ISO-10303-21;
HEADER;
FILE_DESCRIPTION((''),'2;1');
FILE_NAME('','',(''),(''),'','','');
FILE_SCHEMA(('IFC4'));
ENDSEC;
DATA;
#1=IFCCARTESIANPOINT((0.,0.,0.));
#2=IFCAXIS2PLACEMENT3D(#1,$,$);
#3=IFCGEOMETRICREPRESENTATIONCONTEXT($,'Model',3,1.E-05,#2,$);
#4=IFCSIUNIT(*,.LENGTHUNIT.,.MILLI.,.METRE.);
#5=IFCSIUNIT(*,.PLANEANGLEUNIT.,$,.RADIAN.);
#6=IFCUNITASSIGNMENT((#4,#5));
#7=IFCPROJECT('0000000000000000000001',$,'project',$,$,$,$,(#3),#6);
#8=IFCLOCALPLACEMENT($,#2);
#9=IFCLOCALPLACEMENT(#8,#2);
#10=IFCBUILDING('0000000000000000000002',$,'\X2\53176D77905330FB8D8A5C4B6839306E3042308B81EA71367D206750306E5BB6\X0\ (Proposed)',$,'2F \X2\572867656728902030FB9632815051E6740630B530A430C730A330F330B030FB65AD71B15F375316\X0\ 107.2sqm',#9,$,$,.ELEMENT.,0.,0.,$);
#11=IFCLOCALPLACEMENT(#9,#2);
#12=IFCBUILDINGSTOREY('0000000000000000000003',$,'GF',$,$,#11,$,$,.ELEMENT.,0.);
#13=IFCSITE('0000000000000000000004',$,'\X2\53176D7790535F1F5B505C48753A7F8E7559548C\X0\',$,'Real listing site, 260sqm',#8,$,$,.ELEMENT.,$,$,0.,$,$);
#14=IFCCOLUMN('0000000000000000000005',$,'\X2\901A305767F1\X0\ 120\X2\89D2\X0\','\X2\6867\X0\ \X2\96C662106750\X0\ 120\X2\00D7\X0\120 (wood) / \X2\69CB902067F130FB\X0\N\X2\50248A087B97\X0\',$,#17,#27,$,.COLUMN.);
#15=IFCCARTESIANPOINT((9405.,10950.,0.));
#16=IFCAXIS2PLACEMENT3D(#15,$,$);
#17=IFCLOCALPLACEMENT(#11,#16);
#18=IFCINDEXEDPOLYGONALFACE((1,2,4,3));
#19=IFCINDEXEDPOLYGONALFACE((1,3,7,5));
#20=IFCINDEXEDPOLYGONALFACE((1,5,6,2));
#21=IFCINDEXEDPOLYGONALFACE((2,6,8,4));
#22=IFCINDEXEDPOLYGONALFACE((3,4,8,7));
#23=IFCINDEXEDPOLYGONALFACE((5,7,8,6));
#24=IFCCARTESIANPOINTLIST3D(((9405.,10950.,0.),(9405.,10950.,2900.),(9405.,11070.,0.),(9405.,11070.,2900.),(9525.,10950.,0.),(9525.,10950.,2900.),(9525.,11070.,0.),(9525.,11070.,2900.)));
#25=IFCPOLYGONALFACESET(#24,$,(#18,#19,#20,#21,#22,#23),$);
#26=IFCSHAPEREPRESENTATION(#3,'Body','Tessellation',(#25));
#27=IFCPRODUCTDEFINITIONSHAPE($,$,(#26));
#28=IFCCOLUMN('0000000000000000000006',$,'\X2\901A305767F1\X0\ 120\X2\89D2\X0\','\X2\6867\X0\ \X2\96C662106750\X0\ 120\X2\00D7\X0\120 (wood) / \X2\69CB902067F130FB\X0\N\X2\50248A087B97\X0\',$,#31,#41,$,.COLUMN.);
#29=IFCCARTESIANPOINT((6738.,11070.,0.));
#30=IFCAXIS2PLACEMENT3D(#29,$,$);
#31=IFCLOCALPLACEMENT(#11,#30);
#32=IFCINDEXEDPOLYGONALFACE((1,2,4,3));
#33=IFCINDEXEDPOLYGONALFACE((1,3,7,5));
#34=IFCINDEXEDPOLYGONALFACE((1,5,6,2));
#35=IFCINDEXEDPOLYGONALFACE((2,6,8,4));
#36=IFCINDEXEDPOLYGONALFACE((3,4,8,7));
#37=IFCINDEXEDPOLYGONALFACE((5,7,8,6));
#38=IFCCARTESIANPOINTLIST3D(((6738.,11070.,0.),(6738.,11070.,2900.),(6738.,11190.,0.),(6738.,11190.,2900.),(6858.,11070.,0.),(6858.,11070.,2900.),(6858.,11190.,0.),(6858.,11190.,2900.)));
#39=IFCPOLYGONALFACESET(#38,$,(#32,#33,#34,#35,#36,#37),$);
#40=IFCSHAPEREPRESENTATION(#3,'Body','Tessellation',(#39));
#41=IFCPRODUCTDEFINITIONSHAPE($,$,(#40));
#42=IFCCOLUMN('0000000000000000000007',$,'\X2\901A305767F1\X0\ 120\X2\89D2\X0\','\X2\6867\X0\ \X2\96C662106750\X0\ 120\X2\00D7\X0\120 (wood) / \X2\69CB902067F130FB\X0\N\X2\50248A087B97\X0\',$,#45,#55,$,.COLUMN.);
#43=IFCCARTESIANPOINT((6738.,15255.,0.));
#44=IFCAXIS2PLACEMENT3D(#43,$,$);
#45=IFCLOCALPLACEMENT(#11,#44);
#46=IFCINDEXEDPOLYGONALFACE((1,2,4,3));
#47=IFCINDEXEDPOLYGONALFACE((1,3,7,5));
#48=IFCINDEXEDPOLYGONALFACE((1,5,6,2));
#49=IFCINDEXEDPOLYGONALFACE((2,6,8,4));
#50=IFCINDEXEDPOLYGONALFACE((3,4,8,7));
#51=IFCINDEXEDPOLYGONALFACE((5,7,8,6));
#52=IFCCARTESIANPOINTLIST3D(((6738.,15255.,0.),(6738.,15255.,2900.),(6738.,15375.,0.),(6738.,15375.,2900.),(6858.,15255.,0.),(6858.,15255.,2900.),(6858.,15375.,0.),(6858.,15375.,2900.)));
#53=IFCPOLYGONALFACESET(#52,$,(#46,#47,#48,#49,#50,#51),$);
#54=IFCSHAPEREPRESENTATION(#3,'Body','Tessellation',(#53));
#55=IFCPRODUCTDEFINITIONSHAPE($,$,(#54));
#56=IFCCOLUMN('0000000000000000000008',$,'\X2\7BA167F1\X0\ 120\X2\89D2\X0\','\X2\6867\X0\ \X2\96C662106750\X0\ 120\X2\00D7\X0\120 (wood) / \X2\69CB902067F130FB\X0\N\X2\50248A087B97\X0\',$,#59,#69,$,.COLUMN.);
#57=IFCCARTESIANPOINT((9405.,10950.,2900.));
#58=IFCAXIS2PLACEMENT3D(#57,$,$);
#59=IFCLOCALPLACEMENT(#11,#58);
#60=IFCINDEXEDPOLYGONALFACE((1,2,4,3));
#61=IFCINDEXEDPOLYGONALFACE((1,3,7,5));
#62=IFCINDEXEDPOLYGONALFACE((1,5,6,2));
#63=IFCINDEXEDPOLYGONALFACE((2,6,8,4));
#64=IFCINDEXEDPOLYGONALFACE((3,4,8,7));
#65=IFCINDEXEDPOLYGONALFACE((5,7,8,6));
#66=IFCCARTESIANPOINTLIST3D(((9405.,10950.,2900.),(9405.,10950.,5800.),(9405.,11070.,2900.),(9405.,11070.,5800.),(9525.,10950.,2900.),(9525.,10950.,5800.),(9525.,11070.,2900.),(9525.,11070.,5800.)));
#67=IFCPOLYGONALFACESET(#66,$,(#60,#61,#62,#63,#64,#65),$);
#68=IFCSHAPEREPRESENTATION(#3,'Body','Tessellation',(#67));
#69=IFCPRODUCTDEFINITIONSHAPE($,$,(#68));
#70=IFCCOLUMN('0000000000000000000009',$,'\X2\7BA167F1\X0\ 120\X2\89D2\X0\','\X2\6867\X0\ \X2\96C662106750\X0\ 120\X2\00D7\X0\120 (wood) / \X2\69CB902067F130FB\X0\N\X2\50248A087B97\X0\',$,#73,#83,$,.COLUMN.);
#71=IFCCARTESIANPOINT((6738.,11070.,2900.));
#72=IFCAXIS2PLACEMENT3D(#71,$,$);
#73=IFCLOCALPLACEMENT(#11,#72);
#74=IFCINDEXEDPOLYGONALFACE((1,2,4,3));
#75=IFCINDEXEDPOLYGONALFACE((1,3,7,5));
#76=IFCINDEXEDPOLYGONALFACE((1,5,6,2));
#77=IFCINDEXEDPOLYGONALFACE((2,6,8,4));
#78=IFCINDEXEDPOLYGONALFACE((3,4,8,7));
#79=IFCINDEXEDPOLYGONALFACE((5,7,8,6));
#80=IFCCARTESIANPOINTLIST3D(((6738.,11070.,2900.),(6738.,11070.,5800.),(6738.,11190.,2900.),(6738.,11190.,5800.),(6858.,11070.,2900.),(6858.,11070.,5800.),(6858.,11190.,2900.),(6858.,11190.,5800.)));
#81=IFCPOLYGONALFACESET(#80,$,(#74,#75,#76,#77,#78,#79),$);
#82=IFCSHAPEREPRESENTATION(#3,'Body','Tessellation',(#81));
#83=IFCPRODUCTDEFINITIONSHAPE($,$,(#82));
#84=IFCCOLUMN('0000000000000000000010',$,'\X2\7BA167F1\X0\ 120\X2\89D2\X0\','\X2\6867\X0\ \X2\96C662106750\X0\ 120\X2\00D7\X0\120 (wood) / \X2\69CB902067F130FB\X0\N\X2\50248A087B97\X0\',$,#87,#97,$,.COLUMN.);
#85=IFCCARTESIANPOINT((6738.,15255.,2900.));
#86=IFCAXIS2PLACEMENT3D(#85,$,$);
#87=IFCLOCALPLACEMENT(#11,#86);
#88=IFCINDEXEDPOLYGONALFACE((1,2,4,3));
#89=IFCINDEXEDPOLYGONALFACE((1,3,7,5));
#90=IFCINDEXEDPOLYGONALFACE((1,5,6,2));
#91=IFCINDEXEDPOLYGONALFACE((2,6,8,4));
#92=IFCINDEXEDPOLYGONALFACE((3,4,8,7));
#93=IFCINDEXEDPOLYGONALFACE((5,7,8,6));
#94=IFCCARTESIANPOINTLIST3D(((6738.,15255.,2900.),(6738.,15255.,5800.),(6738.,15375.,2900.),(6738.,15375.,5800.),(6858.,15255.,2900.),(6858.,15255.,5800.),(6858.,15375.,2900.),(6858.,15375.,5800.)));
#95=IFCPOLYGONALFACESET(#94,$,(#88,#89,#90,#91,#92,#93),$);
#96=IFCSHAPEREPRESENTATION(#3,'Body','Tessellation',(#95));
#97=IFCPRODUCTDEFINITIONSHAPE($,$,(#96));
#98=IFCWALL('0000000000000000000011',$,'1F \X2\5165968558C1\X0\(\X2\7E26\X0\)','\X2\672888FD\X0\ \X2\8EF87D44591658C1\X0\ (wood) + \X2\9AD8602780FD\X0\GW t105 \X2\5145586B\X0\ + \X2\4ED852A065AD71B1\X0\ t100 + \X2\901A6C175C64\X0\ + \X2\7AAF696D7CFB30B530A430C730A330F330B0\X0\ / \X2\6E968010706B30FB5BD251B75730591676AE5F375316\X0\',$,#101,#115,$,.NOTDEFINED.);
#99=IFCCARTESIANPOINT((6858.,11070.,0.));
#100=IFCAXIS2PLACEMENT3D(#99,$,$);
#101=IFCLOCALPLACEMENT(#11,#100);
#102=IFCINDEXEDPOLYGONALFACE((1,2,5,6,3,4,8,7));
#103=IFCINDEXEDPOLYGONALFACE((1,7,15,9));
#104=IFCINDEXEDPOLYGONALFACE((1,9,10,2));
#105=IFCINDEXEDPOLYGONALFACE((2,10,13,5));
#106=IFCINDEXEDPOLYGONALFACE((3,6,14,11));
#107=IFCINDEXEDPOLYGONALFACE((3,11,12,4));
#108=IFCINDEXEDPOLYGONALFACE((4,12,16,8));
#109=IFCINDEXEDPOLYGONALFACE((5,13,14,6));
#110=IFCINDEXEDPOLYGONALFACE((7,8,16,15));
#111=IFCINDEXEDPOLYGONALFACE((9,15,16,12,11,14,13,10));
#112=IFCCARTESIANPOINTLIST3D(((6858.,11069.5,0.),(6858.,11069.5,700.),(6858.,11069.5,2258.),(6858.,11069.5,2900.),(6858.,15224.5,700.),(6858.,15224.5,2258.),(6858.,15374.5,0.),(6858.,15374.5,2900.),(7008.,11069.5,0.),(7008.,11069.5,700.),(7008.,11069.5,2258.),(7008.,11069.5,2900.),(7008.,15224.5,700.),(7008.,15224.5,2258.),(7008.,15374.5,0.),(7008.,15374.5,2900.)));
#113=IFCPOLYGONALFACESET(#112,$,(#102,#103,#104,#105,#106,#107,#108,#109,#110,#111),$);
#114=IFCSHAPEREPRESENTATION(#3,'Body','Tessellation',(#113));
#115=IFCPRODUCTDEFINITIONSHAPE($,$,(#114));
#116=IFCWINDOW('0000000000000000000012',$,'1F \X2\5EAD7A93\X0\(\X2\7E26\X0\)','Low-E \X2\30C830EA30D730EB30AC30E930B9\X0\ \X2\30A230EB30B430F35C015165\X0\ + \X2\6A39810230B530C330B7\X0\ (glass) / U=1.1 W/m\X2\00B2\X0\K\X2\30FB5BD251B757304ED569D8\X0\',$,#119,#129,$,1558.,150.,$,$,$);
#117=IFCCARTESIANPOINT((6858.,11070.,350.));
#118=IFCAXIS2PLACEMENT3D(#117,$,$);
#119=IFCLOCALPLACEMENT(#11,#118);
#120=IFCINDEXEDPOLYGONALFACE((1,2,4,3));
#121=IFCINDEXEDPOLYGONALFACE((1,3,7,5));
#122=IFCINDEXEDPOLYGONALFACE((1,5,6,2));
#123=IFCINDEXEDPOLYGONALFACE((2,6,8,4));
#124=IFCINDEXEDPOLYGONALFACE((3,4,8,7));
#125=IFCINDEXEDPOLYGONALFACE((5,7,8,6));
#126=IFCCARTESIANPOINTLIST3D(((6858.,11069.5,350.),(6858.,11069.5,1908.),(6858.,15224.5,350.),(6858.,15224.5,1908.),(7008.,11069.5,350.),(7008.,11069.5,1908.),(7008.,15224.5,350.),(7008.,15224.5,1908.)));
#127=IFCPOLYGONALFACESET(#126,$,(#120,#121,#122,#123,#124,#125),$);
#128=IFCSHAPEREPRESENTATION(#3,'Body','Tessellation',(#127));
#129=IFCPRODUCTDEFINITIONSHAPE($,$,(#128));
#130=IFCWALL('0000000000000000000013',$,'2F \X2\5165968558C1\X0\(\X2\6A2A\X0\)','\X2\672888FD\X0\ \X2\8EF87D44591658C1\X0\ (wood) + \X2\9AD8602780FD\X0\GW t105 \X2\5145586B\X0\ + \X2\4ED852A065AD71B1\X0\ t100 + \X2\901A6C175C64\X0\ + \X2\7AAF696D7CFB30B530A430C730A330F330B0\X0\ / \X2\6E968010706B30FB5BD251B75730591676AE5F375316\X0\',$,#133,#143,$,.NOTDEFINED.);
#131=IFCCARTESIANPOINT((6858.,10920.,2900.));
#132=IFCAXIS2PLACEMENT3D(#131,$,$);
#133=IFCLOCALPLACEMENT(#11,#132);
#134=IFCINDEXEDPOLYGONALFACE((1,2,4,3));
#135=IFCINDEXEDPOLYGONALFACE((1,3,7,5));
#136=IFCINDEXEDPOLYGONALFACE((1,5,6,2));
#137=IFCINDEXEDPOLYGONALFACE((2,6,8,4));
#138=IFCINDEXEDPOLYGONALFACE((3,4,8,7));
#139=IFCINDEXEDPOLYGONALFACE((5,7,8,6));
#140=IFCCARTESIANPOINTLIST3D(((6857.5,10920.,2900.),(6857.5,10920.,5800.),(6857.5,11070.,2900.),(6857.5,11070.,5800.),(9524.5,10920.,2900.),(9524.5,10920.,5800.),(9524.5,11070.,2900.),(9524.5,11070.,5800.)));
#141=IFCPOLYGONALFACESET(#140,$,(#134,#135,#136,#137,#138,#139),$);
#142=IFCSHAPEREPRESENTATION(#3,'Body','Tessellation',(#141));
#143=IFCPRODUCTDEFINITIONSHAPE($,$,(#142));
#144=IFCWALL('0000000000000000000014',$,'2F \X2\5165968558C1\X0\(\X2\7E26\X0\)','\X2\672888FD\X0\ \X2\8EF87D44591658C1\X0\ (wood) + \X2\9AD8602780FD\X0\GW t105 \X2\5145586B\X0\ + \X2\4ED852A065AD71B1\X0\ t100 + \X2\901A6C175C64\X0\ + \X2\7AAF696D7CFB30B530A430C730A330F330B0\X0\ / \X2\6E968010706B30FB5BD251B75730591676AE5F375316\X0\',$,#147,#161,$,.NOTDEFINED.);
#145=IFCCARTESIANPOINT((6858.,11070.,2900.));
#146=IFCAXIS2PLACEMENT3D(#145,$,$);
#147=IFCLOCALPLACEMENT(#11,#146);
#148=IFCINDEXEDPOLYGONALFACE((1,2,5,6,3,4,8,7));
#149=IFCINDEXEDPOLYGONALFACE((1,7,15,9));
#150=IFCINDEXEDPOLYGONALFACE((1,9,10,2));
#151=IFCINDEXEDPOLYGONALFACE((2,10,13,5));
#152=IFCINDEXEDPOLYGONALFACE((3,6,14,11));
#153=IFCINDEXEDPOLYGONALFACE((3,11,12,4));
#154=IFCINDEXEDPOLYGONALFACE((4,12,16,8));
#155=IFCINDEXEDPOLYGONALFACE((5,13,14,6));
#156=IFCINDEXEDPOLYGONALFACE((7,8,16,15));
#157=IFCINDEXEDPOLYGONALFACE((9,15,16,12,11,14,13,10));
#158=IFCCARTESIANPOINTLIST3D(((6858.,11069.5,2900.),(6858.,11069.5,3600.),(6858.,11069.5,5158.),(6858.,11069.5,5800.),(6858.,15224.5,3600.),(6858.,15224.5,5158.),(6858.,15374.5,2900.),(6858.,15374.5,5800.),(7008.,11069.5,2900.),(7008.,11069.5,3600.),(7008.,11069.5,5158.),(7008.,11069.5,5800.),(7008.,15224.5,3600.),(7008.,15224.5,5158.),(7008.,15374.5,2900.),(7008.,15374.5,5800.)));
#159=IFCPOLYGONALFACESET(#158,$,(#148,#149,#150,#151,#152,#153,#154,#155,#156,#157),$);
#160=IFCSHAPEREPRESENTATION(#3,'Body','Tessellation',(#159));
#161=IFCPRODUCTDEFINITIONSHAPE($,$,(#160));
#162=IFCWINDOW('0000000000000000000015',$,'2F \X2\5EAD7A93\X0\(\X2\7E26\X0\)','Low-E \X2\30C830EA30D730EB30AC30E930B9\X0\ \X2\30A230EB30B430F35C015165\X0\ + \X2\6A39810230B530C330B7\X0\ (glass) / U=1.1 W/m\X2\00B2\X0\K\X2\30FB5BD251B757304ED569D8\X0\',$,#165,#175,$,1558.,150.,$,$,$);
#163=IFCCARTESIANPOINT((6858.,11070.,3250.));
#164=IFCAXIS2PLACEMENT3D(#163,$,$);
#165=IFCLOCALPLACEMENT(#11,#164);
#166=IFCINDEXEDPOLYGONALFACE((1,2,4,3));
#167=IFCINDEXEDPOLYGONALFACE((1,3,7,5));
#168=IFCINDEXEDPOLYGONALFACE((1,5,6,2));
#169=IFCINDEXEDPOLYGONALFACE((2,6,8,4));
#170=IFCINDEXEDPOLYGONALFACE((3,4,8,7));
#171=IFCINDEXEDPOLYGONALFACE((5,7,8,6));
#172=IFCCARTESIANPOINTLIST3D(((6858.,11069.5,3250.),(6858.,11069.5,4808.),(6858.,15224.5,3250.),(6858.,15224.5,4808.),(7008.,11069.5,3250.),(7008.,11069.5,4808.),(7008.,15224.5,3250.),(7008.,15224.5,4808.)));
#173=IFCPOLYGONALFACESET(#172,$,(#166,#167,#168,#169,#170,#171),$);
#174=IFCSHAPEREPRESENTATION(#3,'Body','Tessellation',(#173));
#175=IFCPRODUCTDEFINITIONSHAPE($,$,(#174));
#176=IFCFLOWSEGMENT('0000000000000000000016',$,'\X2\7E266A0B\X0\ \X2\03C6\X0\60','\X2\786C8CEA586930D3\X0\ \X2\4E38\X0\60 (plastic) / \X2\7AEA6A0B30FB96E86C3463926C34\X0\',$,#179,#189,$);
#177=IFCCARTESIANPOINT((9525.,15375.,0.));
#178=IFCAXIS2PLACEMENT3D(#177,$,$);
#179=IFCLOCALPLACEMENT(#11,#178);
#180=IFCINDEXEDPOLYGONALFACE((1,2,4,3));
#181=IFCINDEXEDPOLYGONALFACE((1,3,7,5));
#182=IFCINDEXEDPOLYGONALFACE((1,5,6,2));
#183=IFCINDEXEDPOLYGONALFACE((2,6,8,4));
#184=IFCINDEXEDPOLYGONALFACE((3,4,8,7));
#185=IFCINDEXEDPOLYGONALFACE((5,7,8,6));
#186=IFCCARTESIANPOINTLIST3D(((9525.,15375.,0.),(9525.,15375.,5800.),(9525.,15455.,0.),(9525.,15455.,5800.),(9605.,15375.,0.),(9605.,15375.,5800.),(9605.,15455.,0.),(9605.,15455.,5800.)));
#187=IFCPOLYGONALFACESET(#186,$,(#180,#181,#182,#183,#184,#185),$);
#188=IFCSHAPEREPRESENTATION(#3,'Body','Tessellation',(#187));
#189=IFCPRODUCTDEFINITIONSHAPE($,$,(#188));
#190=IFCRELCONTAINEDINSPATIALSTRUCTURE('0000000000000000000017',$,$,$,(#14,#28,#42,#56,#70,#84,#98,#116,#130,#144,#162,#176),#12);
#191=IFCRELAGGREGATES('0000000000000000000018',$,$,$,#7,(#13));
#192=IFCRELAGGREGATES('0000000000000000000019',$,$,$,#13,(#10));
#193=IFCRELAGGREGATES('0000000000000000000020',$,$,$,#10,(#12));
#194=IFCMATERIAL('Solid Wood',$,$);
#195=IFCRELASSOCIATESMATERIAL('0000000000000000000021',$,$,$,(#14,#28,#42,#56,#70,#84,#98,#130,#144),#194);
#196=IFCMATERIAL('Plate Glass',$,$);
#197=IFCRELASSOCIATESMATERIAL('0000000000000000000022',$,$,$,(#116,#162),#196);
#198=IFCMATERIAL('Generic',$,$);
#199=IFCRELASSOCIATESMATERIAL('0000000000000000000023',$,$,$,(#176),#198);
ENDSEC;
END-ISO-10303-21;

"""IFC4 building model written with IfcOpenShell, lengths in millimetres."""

from ifc_helpers import new_model, si_unit, frame, frame_2d, origin, place, context, project, spatial, rectangle, extrude, material, element, fill, save


model = new_model("IFC4")

# Units and contexts
model_context = context("Model", 3, precision=1e-05, world=origin())
ifc_project = project(units=[si_unit("LENGTHUNIT", "METRE", prefix="MILLI"), si_unit("PLANEANGLEUNIT", "RADIAN")], contexts=[model_context])

# Site, building, storey
site_placement = place(None, origin())
site = spatial("IfcSite", under=ifc_project, at=site_placement, Name="北海道弟子屈町美留和", ObjectType="Real listing site, 260sqm", CompositionType="ELEMENT", RefElevation=0.0)
building_placement = place(site_placement, origin())
building = spatial("IfcBuilding", under=site, at=building_placement, Name="北海道・越屋根のある自然素材の家 (Proposed)", ObjectType="2F 在来木造・防腐処理サイディング・断熱強化 107.2sqm", CompositionType="ELEMENT", ElevationOfRefHeight=0.0, ElevationOfTerrain=0.0)
storey_placement = place(building_placement, origin())
storey = spatial("IfcBuildingStorey", under=building, at=storey_placement, Name="GF", CompositionType="ELEMENT", Elevation=0.0)

# Columns
ifc_material_1 = material(Name="Solid Wood")
column_1_placement = place(storey_placement, frame((9405.0, 10950.0, 0.0)))
element("IfcColumn", 1, at=column_1_placement, inside=storey, material=ifc_material_1, Name="通し柱 120角", Description="桧 集成材 120×120 (wood) / 構造柱・N値計算", PredefinedType="COLUMN", context=model_context, shape_type="SweptSolid", body=[
    extrude(rectangle(XDim=120.0, YDim=120.0, at=frame_2d((60.0, 60.0))), frame((9405.0, 10950.0, 0.0)), (0.0, 0.0, 1.0), 2900.0),
])
column_2_placement = place(storey_placement, frame((6738.0, 11070.0, 0.0)))
element("IfcColumn", 2, at=column_2_placement, inside=storey, material=ifc_material_1, Name="通し柱 120角", Description="桧 集成材 120×120 (wood) / 構造柱・N値計算", PredefinedType="COLUMN", context=model_context, shape_type="SweptSolid", body=[
    extrude(rectangle(XDim=120.0, YDim=120.0, at=frame_2d((60.0, 60.0))), frame((6738.0, 11070.0, 0.0)), (0.0, 0.0, 1.0), 2900.0),
])
column_3_placement = place(storey_placement, frame((6738.0, 15255.0, 0.0)))
element("IfcColumn", 3, at=column_3_placement, inside=storey, material=ifc_material_1, Name="通し柱 120角", Description="桧 集成材 120×120 (wood) / 構造柱・N値計算", PredefinedType="COLUMN", context=model_context, shape_type="SweptSolid", body=[
    extrude(rectangle(XDim=120.0, YDim=120.0, at=frame_2d((60.0, 60.0))), frame((6738.0, 15255.0, 0.0)), (0.0, 0.0, 1.0), 2900.0),
])
column_4_placement = place(storey_placement, frame((9405.0, 10950.0, 2900.0)))
element("IfcColumn", 4, at=column_4_placement, inside=storey, material=ifc_material_1, Name="管柱 120角", Description="桧 集成材 120×120 (wood) / 構造柱・N値計算", PredefinedType="COLUMN", context=model_context, shape_type="SweptSolid", body=[
    extrude(rectangle(XDim=120.0, YDim=120.0, at=frame_2d((60.0, 60.0))), frame((9405.0, 10950.0, 2900.0)), (0.0, 0.0, 1.0), 2900.0),
])
column_5_placement = place(storey_placement, frame((6738.0, 11070.0, 2900.0)))
element("IfcColumn", 5, at=column_5_placement, inside=storey, material=ifc_material_1, Name="管柱 120角", Description="桧 集成材 120×120 (wood) / 構造柱・N値計算", PredefinedType="COLUMN", context=model_context, shape_type="SweptSolid", body=[
    extrude(rectangle(XDim=120.0, YDim=120.0, at=frame_2d((60.0, 60.0))), frame((6738.0, 11070.0, 2900.0)), (0.0, 0.0, 1.0), 2900.0),
])
column_6_placement = place(storey_placement, frame((6738.0, 15255.0, 2900.0)))
element("IfcColumn", 6, at=column_6_placement, inside=storey, material=ifc_material_1, Name="管柱 120角", Description="桧 集成材 120×120 (wood) / 構造柱・N値計算", PredefinedType="COLUMN", context=model_context, shape_type="SweptSolid", body=[
    extrude(rectangle(XDim=120.0, YDim=120.0, at=frame_2d((60.0, 60.0))), frame((6738.0, 15255.0, 2900.0)), (0.0, 0.0, 1.0), 2900.0),
])

# Wall, opening, window
wall_1_placement = place(storey_placement, frame((6858.0, 11070.0, 0.0)))
wall_1 = element("IfcWall", 7, at=wall_1_placement, inside=storey, material=ifc_material_1, Name="1F 入隅壁(縦)", Description="木製 軸組外壁 (wood) + 高性能GW t105 充填 + 付加断熱 t100 + 通気層 + 窯業系サイディング / 準耐火・寒冷地外皮強化", PredefinedType="NOTDEFINED", context=model_context, shape_type="SweptSolid", body=[
    extrude(rectangle(XDim=150.0, YDim=4305.0, at=frame_2d((75.0, 2152.0))), frame((6858.0, 11070.0, 0.0)), (0.0, 0.0, 1.0), 2900.0),
])
opening_1_placement = place(storey_placement, frame((6858.0, 11070.0, 350.0)))
opening_1 = element("IfcOpeningElement", 8, at=opening_1_placement, cuts=wall_1, PredefinedType="NOTDEFINED", context=model_context, shape_type="SweptSolid", body=[
    extrude(rectangle(XDim=150.0, YDim=4155.0, at=frame_2d((75.0, 2077.0))), frame((6858.0, 11070.0, 350.0)), (0.0, 0.0, 1.0), 1558.0),
])
ifc_material_2 = material(Name="Plate Glass")
window_1_placement = place(storey_placement, frame((6858.0, 11070.0, 350.0)))
window_1 = element("IfcWindow", 9, at=window_1_placement, inside=storey, material=ifc_material_2, Name="1F 庭窓(縦)", Description="Low-E トリプルガラス アルゴン封入 + 樹脂サッシ (glass) / U=1.1 W/m²K・寒冷地仕様", OverallHeight=1558.0, OverallWidth=150.0, context=model_context, shape_type="SweptSolid", body=[
    extrude(rectangle(XDim=150.0, YDim=4155.0, at=frame_2d((75.0, 2077.0))), frame((6858.0, 11070.0, 350.0)), (0.0, 0.0, 1.0), 1558.0),
])
fill(opening_1, window_1)

# Wall
wall_2_placement = place(storey_placement, frame((6858.0, 10920.0, 2900.0)))
element("IfcWall", 10, at=wall_2_placement, inside=storey, material=ifc_material_1, Name="2F 入隅壁(横)", Description="木製 軸組外壁 (wood) + 高性能GW t105 充填 + 付加断熱 t100 + 通気層 + 窯業系サイディング / 準耐火・寒冷地外皮強化", PredefinedType="NOTDEFINED", context=model_context, shape_type="SweptSolid", body=[
    extrude(rectangle(XDim=2667.0, YDim=150.0, at=frame_2d((1333.0, 75.0))), frame((6858.0, 10920.0, 2900.0)), (0.0, 0.0, 1.0), 2900.0),
])

# Wall, opening, window
wall_3_placement = place(storey_placement, frame((6858.0, 11070.0, 2900.0)))
wall_3 = element("IfcWall", 11, at=wall_3_placement, inside=storey, material=ifc_material_1, Name="2F 入隅壁(縦)", Description="木製 軸組外壁 (wood) + 高性能GW t105 充填 + 付加断熱 t100 + 通気層 + 窯業系サイディング / 準耐火・寒冷地外皮強化", PredefinedType="NOTDEFINED", context=model_context, shape_type="SweptSolid", body=[
    extrude(rectangle(XDim=150.0, YDim=4305.0, at=frame_2d((75.0, 2152.0))), frame((6858.0, 11070.0, 2900.0)), (0.0, 0.0, 1.0), 2900.0),
])
opening_2_placement = place(storey_placement, frame((6858.0, 11070.0, 3250.0)))
opening_2 = element("IfcOpeningElement", 12, at=opening_2_placement, cuts=wall_3, PredefinedType="NOTDEFINED", context=model_context, shape_type="SweptSolid", body=[
    extrude(rectangle(XDim=150.0, YDim=4155.0, at=frame_2d((75.0, 2077.0))), frame((6858.0, 11070.0, 3250.0)), (0.0, 0.0, 1.0), 1558.0),
])
window_2_placement = place(storey_placement, frame((6858.0, 11070.0, 3250.0)))
window_2 = element("IfcWindow", 13, at=window_2_placement, inside=storey, material=ifc_material_2, Name="2F 庭窓(縦)", Description="Low-E トリプルガラス アルゴン封入 + 樹脂サッシ (glass) / U=1.1 W/m²K・寒冷地仕様", OverallHeight=1558.0, OverallWidth=150.0, context=model_context, shape_type="SweptSolid", body=[
    extrude(rectangle(XDim=150.0, YDim=4155.0, at=frame_2d((75.0, 2077.0))), frame((6858.0, 11070.0, 3250.0)), (0.0, 0.0, 1.0), 1558.0),
])
fill(opening_2, window_2)

# Flow segment
ifc_material_3 = material(Name="Generic")
flow_segment_placement = place(storey_placement, frame((9525.0, 15375.0, 0.0)))
element("IfcFlowSegment", 14, at=flow_segment_placement, inside=storey, material=ifc_material_3, Name="縦樋 φ60", Description="硬質塩ビ 丸60 (plastic) / 竪樋・雨水排水", context=model_context, shape_type="SweptSolid", body=[
    extrude(rectangle(XDim=80.0, YDim=80.0, at=frame_2d((40.0, 40.0))), frame((9525.0, 15375.0, 0.0)), (0.0, 0.0, 1.0), 5800.0),
])

save(model, "model.ifc")
